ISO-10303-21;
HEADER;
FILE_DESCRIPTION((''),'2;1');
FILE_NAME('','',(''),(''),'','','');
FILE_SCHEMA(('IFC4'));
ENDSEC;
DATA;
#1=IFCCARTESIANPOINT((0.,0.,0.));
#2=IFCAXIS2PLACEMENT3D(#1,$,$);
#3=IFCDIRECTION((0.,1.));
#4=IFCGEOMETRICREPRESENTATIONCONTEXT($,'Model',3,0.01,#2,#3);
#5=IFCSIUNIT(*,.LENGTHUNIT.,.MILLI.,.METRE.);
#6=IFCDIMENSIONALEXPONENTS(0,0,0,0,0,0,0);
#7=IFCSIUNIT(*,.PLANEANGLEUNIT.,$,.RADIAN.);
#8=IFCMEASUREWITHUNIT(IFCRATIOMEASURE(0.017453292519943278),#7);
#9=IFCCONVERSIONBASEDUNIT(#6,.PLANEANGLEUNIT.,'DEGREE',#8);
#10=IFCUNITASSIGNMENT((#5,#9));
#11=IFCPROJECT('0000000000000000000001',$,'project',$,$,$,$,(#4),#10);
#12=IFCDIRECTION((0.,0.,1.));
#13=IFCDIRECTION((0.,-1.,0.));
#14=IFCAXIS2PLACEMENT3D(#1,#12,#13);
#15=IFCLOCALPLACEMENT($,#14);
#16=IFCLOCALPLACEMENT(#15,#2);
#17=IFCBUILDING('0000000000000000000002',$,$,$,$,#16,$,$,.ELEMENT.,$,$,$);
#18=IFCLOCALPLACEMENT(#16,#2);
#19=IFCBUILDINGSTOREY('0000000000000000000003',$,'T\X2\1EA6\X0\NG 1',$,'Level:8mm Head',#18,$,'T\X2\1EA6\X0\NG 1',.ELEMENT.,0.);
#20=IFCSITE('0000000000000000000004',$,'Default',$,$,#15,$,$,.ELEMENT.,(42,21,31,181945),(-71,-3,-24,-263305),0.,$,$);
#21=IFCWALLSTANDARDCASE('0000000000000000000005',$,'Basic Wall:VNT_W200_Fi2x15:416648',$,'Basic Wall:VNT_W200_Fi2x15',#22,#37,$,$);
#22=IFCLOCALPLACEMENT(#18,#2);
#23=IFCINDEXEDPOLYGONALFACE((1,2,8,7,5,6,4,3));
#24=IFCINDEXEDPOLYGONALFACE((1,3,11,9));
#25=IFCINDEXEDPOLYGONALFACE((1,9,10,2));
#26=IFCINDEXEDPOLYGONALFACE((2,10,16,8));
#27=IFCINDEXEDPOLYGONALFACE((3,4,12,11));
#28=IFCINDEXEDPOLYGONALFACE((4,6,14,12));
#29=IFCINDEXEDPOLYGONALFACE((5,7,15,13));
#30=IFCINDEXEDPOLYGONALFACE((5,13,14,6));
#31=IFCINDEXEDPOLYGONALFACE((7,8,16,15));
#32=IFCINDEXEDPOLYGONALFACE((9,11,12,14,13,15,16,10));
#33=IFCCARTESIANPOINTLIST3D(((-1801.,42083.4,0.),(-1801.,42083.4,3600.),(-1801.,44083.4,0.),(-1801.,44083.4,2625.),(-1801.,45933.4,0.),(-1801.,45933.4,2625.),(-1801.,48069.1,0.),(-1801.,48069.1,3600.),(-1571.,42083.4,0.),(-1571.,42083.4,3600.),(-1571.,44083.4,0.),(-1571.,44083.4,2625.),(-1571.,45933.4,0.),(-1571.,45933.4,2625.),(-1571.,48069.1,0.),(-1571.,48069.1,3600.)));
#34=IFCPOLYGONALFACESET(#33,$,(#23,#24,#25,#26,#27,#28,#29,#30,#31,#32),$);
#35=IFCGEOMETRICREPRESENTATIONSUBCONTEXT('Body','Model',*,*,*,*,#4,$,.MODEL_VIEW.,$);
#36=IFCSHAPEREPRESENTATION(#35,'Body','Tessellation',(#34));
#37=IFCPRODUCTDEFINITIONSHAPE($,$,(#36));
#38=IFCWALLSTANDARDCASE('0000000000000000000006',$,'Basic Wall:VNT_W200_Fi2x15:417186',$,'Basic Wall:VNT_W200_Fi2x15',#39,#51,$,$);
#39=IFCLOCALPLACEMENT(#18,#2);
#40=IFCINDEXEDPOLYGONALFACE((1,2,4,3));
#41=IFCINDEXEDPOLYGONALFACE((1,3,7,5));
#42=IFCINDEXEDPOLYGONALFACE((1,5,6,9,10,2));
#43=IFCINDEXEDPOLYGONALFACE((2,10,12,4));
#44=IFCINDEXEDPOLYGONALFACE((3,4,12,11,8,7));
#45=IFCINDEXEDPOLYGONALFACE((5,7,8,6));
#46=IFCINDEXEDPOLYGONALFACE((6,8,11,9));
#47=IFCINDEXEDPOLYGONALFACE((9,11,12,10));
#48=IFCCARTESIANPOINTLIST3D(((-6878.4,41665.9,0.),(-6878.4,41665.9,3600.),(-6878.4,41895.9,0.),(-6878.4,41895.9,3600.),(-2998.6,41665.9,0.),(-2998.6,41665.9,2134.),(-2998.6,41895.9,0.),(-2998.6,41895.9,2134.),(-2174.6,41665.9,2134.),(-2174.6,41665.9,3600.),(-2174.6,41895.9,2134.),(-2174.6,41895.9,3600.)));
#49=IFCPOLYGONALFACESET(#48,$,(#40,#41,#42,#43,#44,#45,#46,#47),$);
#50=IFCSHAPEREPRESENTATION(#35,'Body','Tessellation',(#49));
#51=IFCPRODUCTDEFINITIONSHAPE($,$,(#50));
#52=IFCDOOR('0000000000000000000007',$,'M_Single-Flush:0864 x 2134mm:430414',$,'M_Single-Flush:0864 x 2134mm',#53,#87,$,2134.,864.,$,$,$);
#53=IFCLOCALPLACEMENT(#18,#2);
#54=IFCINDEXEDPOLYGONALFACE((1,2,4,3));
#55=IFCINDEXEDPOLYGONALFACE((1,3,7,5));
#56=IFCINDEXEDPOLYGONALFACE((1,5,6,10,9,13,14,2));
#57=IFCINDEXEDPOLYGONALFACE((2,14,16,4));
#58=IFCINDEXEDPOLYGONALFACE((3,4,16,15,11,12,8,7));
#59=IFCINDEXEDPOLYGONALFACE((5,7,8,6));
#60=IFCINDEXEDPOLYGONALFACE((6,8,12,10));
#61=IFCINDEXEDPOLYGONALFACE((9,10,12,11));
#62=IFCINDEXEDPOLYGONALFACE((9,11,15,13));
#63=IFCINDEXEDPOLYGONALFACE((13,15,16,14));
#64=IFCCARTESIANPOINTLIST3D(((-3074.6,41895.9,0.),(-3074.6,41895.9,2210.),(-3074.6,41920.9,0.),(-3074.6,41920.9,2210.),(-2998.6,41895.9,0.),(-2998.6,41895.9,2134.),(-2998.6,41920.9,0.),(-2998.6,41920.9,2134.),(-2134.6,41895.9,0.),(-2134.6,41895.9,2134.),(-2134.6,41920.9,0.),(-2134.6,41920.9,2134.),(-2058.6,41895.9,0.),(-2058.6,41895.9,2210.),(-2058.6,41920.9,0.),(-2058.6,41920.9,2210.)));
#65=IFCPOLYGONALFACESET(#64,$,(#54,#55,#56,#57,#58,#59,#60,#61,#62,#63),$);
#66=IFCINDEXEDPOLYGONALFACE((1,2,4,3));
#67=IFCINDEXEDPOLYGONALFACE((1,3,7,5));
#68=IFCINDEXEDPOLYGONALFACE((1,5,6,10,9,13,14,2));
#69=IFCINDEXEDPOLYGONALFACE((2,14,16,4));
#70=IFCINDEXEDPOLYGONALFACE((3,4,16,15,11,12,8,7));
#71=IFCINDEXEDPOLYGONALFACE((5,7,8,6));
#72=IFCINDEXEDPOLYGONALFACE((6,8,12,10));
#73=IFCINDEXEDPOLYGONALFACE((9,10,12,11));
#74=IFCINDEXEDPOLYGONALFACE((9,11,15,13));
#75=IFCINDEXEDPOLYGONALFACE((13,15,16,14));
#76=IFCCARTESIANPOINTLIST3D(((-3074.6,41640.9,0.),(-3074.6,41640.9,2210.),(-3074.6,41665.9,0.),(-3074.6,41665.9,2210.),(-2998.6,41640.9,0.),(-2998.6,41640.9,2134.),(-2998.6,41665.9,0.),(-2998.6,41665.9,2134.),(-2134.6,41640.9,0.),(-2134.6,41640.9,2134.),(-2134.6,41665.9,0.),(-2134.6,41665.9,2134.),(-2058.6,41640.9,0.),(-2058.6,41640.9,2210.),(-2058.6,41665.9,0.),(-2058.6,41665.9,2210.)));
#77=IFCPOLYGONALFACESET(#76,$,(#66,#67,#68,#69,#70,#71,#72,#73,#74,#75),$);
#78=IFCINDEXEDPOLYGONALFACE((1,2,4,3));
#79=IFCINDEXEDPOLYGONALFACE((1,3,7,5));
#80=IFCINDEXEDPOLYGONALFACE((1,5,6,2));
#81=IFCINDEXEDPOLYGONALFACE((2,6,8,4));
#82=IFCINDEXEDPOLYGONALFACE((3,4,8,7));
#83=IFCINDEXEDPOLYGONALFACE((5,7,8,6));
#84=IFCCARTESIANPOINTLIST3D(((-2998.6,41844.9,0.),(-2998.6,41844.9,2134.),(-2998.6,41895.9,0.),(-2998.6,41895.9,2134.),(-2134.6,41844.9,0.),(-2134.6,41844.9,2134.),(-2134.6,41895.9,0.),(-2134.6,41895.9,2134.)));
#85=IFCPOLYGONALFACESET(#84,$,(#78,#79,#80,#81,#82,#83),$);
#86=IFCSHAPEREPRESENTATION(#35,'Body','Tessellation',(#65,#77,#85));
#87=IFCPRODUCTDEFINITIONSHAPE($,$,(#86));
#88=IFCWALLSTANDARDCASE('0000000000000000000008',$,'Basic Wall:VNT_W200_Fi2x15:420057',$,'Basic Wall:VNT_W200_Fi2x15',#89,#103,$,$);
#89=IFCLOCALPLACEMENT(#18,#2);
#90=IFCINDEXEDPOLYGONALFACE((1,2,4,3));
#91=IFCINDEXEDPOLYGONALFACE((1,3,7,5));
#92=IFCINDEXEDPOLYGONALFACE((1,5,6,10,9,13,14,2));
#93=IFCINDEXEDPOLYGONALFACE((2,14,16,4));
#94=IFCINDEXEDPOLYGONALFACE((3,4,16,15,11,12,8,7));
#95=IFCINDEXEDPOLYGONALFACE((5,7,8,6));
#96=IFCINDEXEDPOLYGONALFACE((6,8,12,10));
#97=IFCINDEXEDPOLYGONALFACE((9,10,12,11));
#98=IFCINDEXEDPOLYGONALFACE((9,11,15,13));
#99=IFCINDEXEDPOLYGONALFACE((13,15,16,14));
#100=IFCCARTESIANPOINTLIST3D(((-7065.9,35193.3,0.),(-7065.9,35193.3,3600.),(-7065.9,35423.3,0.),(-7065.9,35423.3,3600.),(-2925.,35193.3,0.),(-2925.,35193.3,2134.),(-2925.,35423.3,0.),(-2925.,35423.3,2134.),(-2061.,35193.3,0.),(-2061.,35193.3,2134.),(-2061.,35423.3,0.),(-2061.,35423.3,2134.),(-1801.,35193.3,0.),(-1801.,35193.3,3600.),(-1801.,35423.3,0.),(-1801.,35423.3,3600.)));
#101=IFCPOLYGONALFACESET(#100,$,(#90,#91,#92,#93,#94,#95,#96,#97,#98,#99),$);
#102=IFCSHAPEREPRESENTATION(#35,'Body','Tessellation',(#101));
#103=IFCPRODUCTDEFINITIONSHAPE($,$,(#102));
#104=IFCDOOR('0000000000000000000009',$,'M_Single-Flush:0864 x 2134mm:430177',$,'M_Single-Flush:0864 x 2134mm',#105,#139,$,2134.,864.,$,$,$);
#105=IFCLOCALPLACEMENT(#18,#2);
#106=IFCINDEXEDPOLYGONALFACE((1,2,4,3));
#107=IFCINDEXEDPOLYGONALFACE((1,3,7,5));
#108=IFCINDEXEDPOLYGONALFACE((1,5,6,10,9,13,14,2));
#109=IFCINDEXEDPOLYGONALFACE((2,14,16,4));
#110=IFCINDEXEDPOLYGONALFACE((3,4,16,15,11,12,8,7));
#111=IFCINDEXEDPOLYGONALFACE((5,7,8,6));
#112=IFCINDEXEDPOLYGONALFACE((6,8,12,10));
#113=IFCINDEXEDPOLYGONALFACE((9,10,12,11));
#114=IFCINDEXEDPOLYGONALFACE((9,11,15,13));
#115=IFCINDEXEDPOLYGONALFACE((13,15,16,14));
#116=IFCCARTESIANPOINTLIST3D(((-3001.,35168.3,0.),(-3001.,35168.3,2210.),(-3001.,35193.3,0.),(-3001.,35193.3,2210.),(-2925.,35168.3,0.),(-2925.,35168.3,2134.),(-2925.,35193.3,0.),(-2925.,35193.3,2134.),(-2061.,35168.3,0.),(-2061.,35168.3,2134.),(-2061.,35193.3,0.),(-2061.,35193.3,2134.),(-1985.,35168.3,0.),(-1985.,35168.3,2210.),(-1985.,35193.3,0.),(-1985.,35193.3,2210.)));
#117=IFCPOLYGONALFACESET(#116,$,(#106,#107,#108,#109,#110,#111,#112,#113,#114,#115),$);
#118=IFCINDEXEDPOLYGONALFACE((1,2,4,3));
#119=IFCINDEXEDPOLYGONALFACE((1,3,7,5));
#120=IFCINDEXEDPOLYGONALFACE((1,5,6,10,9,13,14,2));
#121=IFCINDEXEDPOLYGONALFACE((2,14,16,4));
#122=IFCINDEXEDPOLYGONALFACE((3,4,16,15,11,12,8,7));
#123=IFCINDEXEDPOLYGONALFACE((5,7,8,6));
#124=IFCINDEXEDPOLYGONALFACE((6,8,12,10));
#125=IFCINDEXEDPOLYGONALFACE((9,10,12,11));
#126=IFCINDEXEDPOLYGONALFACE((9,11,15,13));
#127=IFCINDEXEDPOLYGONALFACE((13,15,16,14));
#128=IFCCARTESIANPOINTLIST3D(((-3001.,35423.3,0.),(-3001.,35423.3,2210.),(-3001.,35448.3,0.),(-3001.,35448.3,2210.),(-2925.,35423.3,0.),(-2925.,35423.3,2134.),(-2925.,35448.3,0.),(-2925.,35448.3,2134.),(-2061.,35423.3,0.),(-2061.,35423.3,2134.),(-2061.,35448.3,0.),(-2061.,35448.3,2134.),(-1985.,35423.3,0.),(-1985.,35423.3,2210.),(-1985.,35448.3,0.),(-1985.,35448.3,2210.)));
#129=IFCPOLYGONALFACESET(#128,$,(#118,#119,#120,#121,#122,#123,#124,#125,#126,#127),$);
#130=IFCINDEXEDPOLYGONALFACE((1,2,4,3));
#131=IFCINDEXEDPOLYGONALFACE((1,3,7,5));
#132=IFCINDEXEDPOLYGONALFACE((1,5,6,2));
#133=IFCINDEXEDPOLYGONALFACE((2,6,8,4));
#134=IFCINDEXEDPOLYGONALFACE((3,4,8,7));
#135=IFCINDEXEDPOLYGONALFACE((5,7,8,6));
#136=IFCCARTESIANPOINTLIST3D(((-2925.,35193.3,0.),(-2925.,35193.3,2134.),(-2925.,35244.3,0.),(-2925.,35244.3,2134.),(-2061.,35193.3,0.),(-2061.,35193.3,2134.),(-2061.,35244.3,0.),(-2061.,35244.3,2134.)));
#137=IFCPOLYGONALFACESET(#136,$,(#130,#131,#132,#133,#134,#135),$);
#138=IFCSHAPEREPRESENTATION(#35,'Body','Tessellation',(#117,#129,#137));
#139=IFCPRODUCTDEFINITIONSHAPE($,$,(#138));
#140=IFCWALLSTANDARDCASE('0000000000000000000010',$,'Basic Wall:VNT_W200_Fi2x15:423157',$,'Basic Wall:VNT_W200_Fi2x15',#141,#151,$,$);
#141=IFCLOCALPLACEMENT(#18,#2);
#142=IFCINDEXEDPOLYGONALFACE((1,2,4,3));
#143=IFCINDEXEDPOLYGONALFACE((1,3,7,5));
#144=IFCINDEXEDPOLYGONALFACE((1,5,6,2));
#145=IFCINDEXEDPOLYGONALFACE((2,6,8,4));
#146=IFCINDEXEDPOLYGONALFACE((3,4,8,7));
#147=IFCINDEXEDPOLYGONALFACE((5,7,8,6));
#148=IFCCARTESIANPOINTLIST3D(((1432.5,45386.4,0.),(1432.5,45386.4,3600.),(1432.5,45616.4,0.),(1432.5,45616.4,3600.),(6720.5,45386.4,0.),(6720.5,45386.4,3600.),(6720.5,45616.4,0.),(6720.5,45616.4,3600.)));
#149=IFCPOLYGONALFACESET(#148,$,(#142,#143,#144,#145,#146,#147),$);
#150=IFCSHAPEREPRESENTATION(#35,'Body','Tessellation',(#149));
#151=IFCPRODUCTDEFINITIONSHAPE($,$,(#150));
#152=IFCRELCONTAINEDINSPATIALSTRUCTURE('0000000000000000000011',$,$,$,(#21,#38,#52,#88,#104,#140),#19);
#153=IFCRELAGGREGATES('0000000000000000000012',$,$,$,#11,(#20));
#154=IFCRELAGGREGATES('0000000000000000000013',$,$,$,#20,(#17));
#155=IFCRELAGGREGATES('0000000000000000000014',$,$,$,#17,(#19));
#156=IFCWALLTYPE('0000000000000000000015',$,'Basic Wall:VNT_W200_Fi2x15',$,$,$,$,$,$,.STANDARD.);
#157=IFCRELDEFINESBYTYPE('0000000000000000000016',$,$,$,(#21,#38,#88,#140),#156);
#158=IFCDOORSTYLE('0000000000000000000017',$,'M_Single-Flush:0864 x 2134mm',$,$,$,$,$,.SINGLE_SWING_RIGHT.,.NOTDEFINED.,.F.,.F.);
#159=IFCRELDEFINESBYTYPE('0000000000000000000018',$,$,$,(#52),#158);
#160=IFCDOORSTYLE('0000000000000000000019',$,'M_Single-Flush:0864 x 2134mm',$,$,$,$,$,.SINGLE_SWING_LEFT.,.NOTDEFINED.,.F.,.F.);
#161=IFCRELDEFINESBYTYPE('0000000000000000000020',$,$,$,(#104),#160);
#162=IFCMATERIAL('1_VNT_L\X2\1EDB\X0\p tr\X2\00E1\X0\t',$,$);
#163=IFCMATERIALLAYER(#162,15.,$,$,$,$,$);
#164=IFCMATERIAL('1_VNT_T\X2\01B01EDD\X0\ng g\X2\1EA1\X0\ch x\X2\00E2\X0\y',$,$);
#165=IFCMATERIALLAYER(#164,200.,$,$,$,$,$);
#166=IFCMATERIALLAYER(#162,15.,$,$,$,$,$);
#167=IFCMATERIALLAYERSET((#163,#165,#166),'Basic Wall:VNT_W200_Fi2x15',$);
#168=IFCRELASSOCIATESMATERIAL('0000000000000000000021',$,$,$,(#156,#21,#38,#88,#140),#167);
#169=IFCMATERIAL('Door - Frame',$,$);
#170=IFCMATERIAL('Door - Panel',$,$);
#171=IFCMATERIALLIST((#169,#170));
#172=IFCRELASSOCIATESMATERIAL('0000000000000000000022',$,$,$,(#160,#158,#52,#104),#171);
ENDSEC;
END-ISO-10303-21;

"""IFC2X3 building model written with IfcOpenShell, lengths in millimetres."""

from ifc_helpers import new_model, entity, si_unit, converted_unit, direction, frame, frame_2d, origin, place, context, subcontext, project, spatial, polyline, rectangle, outline, extrude, source, transform, mapped, material, material_list, layer, layer_set, layer_usage, type_object, type_shapes, element, fill, save


model = new_model("IFC2X3")

# Units and contexts
model_context = context("Model", 3, precision=0.01, world=origin(), true_north=direction((0.0, 1.0)))
body_context = subcontext(model_context, "Body", "Model", "MODEL_VIEW")
ifc_project = project(units=[si_unit("LENGTHUNIT", "METRE", prefix="MILLI"), converted_unit("PLANEANGLEUNIT", "DEGREE", entity("IfcRatioMeasure", 0.017453292519943278), si_unit("PLANEANGLEUNIT", "RADIAN"), dimensions=[0, 0, 0, 0, 0, 0, 0])], contexts=[model_context])

# Site, building, storey
site_placement = place(None, frame((0.0, 0.0, 0.0), z_axis=(0.0, 0.0, 1.0), x_axis=(0.0, -1.0, 0.0)))
site = spatial("IfcSite", under=ifc_project, at=site_placement, Name="Default", CompositionType="ELEMENT", RefLatitude=(42, 21, 31, 181945), RefLongitude=(-71, -3, -24, -263305), RefElevation=0.0)
building_placement = place(site_placement, origin())
building = spatial("IfcBuilding", under=site, at=building_placement, CompositionType="ELEMENT")
storey_placement = place(building_placement, origin())
storey = spatial("IfcBuildingStorey", under=building, at=storey_placement, Name="TẦNG 1", ObjectType="Level:8mm Head", LongName="TẦNG 1", CompositionType="ELEMENT", Elevation=0.0)

# Shared definitions
ifc_material_1 = material(Name="1_VNT_Lớp trát")
ifc_layer_1 = layer(ifc_material_1, 15.0)
ifc_material_2 = material(Name="1_VNT_Tường gạch xây")
ifc_layer_2 = layer(ifc_material_2, 200.0)
ifc_layer_3 = layer(ifc_material_1, 15.0)
ifc_layer_set_1 = layer_set([ifc_layer_1, ifc_layer_2, ifc_layer_3], Name="Basic Wall:VNT_W200_Fi2x15")
ifc_layer_usage_1 = layer_usage(ifc_layer_set_1, "AXIS2", "NEGATIVE", 115.0)
wall_type_1 = type_object("IfcWallType", Name="Basic Wall:VNT_W200_Fi2x15", PredefinedType="STANDARD", material=ifc_layer_set_1)

# Shared definitions
ifc_material_3 = material(Name="Door - Frame")
ifc_material_4 = material(Name="Door - Panel")
ifc_material_list = material_list([ifc_material_3, ifc_material_4])
door_style_1 = type_object("IfcDoorStyle", Name="M_Single-Flush:0864 x 2134mm", ConstructionType="NOTDEFINED", OperationType="SINGLE_SWING_LEFT", ParameterTakesPrecedence=False, Sizeable=False, material=ifc_material_list)
shared_shape_1 = source(origin(), body_context, "Body", "SweptSolid", [
    extrude(outline(polyline([(-508.0, -1124.0), (508.0, -1124.0), (508.0, 1086.0), (432.0, 1086.0), (432.0, -1048.0), (-432.0, -1048.0), (-432.0, 1086.0), (-508.0, 1086.0), (-508.0, -1124.0)])), frame((432.0, 255.0, 1086.0), z_axis=(0.0, -1.0, 0.0), x_axis=(-1.0, 0.0, 0.0)), (0.0, 0.0, 1.0), 25.0),
    extrude(outline(polyline([(-1124.0, -508.0), (1086.0, -508.0), (1086.0, -432.0), (-1048.0, -432.0), (-1048.0, 432.0), (1086.0, 432.0), (1086.0, 508.0), (-1124.0, 508.0), (-1124.0, -508.0)])), frame((432.0, 0.0, 1086.0), z_axis=(0.0, -1.0, 0.0), x_axis=(0.0, 0.0, -1.0)), (0.0, 0.0, 1.0), 25.0),
    extrude(rectangle(XDim=864.0, YDim=51.0, at=frame_2d((0.0, 0.0), x_axis=(1.0, 0.0))), frame((432.0, 204.5, 0.0)), (0.0, 0.0, 1.0), 2134.0),
])
type_shapes(door_style_1, [shared_shape_1])

# Wall, opening
wall_1_placement = place(storey_placement, frame((-1686.0, 48069.1, 0.0), z_axis=(0.0, 0.0, 1.0), x_axis=(0.0, -1.0, 0.0)))
wall_1 = element("IfcWallStandardCase", 1, at=wall_1_placement, inside=storey, type_object=wall_type_1, material=ifc_layer_usage_1, Name="Basic Wall:VNT_W200_Fi2x15:416648", ObjectType="Basic Wall:VNT_W200_Fi2x15", context=body_context, shape_type="SweptSolid", body=[
    extrude(rectangle(XDim=5985.6, YDim=230.0, at=frame_2d((2992.8, 0.0), x_axis=(-1.0, 0.0))), origin(), (0.0, 0.0, 1.0), 3600.0),
])
opening_1_placement = place(wall_1_placement, frame((3985.6, 115.0, 0.0)))
element("IfcOpeningElement", 2, at=opening_1_placement, cuts=wall_1, ObjectType="Opening", context=body_context, shape_type="SweptSolid", body=[
    extrude(rectangle(XDim=2625.0, YDim=1850.0, at=frame_2d((1312.5, 925.0), x_axis=(1.0, 0.0))), frame((0.0, 0.0, 0.0), z_axis=(0.0, -1.0, 0.0), x_axis=(0.0, 0.0, 1.0)), (0.0, 0.0, 1.0), 230.0),
])

# Walls, openings, doors
wall_2_placement = place(storey_placement, frame((-2174.6, 41780.9, 0.0), z_axis=(0.0, 0.0, 1.0), x_axis=(-1.0, 0.0, 0.0)))
wall_2 = element("IfcWallStandardCase", 3, at=wall_2_placement, inside=storey, type_object=wall_type_1, material=ifc_layer_usage_1, Name="Basic Wall:VNT_W200_Fi2x15:417186", ObjectType="Basic Wall:VNT_W200_Fi2x15", context=body_context, shape_type="SweptSolid", body=[
    extrude(rectangle(XDim=4703.8, YDim=230.0, at=frame_2d((2351.9, 0.0), x_axis=(-1.0, 0.0))), origin(), (0.0, 0.0, 1.0), 3600.0),
])
opening_2_placement = place(wall_2_placement, frame((824.0, 115.0, 0.0)))
opening_2 = element("IfcOpeningElement", 4, at=opening_2_placement, cuts=wall_2, ObjectType="Opening", context=body_context, shape_type="SweptSolid", body=[
    extrude(rectangle(XDim=864.0, YDim=2134.0, at=frame_2d((1067.0, 432.0), x_axis=(0.0, 1.0))), frame((0.0, 0.0, 0.0), z_axis=(0.0, -1.0, 0.0), x_axis=(0.0, 0.0, 1.0)), (0.0, 0.0, 1.0), 230.0),
])
door_style_2 = type_object("IfcDoorStyle", Name="M_Single-Flush:0864 x 2134mm", ConstructionType="NOTDEFINED", OperationType="SINGLE_SWING_RIGHT", ParameterTakesPrecedence=False, Sizeable=False, material=ifc_material_list)
shared_shape_2 = source(origin(), body_context, "Body", "SweptSolid", [
    extrude(outline(polyline([(-508.0, -1124.0), (508.0, -1124.0), (508.0, 1086.0), (432.0, 1086.0), (432.0, -1048.0), (-432.0, -1048.0), (-432.0, 1086.0), (-508.0, 1086.0), (-508.0, -1124.0)])), frame((432.0, 230.0, 1086.0), z_axis=(0.0, 1.0, 0.0), x_axis=(1.0, 0.0, 0.0)), (0.0, 0.0, 1.0), 25.0),
    extrude(outline(polyline([(-1124.0, -508.0), (1086.0, -508.0), (1086.0, -432.0), (-1048.0, -432.0), (-1048.0, 432.0), (1086.0, 432.0), (1086.0, 508.0), (-1124.0, 508.0), (-1124.0, -508.0)])), frame((432.0, -25.0, 1086.0), z_axis=(0.0, 1.0, 0.0), x_axis=(0.0, 0.0, -1.0)), (0.0, 0.0, 1.0), 25.0),
    extrude(rectangle(XDim=51.0, YDim=864.0, at=frame_2d((0.0, 0.0), x_axis=(1.0, 0.0))), frame((432.0, 204.5, 0.0), z_axis=(0.0, 0.0, 1.0), x_axis=(0.0, 1.0, 0.0)), (0.0, 0.0, 1.0), 2134.0),
])
type_shapes(door_style_2, [shared_shape_2])
door_1_placement = place(opening_2_placement, frame((0.0, 0.0, 0.0), z_axis=(0.0, 0.0, 1.0), x_axis=(-1.0, 0.0, 0.0)))
door_1 = element("IfcDoor", 5, at=door_1_placement, inside=storey, type_object=door_style_2, material=ifc_material_list, Name="M_Single-Flush:0864 x 2134mm:430414", ObjectType="M_Single-Flush:0864 x 2134mm", OverallHeight=2134.0, OverallWidth=864.0, context=body_context, shape_type="MappedRepresentation", body=[
    mapped(shared_shape_2, transform((0.0, 0.0, 0.0), scale=1.0)),
])
fill(opening_2, door_1)
wall_3_placement = place(storey_placement, frame((-7065.9, 35308.3, 0.0)))
wall_3 = element("IfcWallStandardCase", 6, at=wall_3_placement, inside=storey, type_object=wall_type_1, material=ifc_layer_usage_1, Name="Basic Wall:VNT_W200_Fi2x15:420057", ObjectType="Basic Wall:VNT_W200_Fi2x15", context=body_context, shape_type="SweptSolid", body=[
    extrude(rectangle(XDim=5264.9, YDim=230.0, at=frame_2d((2632.5, 0.0), x_axis=(1.0, 0.0))), origin(), (0.0, 0.0, 1.0), 3600.0),
])
opening_3_placement = place(wall_3_placement, frame((5004.9, 115.0, 0.0)))
opening_3 = element("IfcOpeningElement", 7, at=opening_3_placement, cuts=wall_3, ObjectType="Opening", context=body_context, shape_type="SweptSolid", body=[
    extrude(rectangle(XDim=864.0, YDim=2134.0, at=frame_2d((1067.0, 432.0), x_axis=(0.0, -1.0))), frame((0.0, 0.0, 0.0), z_axis=(0.0, -1.0, 0.0), x_axis=(0.0, 0.0, 1.0)), (0.0, 0.0, 1.0), 230.0),
])
door_2_placement = place(opening_3_placement, frame((0.0, 0.0, 0.0), z_axis=(0.0, 0.0, 1.0), x_axis=(-1.0, 0.0, 0.0)))
door_2 = element("IfcDoor", 8, at=door_2_placement, inside=storey, type_object=door_style_1, material=ifc_material_list, Name="M_Single-Flush:0864 x 2134mm:430177", ObjectType="M_Single-Flush:0864 x 2134mm", OverallHeight=2134.0, OverallWidth=864.0, context=body_context, shape_type="MappedRepresentation", body=[
    mapped(shared_shape_1, transform((0.0, 0.0, 0.0), scale=1.0)),
])
fill(opening_3, door_2)

# Wall
wall_4_placement = place(storey_placement, frame((1432.5, 45501.4, 0.0)))
element("IfcWallStandardCase", 9, at=wall_4_placement, inside=storey, type_object=wall_type_1, material=ifc_layer_usage_1, Name="Basic Wall:VNT_W200_Fi2x15:423157", ObjectType="Basic Wall:VNT_W200_Fi2x15", context=body_context, shape_type="SweptSolid", body=[
    extrude(rectangle(XDim=5288.0, YDim=230.0, at=frame_2d((2644.0, 0.0), x_axis=(-1.0, 0.0))), origin(), (0.0, 0.0, 1.0), 3600.0),
])

save(model, "model.ifc")
